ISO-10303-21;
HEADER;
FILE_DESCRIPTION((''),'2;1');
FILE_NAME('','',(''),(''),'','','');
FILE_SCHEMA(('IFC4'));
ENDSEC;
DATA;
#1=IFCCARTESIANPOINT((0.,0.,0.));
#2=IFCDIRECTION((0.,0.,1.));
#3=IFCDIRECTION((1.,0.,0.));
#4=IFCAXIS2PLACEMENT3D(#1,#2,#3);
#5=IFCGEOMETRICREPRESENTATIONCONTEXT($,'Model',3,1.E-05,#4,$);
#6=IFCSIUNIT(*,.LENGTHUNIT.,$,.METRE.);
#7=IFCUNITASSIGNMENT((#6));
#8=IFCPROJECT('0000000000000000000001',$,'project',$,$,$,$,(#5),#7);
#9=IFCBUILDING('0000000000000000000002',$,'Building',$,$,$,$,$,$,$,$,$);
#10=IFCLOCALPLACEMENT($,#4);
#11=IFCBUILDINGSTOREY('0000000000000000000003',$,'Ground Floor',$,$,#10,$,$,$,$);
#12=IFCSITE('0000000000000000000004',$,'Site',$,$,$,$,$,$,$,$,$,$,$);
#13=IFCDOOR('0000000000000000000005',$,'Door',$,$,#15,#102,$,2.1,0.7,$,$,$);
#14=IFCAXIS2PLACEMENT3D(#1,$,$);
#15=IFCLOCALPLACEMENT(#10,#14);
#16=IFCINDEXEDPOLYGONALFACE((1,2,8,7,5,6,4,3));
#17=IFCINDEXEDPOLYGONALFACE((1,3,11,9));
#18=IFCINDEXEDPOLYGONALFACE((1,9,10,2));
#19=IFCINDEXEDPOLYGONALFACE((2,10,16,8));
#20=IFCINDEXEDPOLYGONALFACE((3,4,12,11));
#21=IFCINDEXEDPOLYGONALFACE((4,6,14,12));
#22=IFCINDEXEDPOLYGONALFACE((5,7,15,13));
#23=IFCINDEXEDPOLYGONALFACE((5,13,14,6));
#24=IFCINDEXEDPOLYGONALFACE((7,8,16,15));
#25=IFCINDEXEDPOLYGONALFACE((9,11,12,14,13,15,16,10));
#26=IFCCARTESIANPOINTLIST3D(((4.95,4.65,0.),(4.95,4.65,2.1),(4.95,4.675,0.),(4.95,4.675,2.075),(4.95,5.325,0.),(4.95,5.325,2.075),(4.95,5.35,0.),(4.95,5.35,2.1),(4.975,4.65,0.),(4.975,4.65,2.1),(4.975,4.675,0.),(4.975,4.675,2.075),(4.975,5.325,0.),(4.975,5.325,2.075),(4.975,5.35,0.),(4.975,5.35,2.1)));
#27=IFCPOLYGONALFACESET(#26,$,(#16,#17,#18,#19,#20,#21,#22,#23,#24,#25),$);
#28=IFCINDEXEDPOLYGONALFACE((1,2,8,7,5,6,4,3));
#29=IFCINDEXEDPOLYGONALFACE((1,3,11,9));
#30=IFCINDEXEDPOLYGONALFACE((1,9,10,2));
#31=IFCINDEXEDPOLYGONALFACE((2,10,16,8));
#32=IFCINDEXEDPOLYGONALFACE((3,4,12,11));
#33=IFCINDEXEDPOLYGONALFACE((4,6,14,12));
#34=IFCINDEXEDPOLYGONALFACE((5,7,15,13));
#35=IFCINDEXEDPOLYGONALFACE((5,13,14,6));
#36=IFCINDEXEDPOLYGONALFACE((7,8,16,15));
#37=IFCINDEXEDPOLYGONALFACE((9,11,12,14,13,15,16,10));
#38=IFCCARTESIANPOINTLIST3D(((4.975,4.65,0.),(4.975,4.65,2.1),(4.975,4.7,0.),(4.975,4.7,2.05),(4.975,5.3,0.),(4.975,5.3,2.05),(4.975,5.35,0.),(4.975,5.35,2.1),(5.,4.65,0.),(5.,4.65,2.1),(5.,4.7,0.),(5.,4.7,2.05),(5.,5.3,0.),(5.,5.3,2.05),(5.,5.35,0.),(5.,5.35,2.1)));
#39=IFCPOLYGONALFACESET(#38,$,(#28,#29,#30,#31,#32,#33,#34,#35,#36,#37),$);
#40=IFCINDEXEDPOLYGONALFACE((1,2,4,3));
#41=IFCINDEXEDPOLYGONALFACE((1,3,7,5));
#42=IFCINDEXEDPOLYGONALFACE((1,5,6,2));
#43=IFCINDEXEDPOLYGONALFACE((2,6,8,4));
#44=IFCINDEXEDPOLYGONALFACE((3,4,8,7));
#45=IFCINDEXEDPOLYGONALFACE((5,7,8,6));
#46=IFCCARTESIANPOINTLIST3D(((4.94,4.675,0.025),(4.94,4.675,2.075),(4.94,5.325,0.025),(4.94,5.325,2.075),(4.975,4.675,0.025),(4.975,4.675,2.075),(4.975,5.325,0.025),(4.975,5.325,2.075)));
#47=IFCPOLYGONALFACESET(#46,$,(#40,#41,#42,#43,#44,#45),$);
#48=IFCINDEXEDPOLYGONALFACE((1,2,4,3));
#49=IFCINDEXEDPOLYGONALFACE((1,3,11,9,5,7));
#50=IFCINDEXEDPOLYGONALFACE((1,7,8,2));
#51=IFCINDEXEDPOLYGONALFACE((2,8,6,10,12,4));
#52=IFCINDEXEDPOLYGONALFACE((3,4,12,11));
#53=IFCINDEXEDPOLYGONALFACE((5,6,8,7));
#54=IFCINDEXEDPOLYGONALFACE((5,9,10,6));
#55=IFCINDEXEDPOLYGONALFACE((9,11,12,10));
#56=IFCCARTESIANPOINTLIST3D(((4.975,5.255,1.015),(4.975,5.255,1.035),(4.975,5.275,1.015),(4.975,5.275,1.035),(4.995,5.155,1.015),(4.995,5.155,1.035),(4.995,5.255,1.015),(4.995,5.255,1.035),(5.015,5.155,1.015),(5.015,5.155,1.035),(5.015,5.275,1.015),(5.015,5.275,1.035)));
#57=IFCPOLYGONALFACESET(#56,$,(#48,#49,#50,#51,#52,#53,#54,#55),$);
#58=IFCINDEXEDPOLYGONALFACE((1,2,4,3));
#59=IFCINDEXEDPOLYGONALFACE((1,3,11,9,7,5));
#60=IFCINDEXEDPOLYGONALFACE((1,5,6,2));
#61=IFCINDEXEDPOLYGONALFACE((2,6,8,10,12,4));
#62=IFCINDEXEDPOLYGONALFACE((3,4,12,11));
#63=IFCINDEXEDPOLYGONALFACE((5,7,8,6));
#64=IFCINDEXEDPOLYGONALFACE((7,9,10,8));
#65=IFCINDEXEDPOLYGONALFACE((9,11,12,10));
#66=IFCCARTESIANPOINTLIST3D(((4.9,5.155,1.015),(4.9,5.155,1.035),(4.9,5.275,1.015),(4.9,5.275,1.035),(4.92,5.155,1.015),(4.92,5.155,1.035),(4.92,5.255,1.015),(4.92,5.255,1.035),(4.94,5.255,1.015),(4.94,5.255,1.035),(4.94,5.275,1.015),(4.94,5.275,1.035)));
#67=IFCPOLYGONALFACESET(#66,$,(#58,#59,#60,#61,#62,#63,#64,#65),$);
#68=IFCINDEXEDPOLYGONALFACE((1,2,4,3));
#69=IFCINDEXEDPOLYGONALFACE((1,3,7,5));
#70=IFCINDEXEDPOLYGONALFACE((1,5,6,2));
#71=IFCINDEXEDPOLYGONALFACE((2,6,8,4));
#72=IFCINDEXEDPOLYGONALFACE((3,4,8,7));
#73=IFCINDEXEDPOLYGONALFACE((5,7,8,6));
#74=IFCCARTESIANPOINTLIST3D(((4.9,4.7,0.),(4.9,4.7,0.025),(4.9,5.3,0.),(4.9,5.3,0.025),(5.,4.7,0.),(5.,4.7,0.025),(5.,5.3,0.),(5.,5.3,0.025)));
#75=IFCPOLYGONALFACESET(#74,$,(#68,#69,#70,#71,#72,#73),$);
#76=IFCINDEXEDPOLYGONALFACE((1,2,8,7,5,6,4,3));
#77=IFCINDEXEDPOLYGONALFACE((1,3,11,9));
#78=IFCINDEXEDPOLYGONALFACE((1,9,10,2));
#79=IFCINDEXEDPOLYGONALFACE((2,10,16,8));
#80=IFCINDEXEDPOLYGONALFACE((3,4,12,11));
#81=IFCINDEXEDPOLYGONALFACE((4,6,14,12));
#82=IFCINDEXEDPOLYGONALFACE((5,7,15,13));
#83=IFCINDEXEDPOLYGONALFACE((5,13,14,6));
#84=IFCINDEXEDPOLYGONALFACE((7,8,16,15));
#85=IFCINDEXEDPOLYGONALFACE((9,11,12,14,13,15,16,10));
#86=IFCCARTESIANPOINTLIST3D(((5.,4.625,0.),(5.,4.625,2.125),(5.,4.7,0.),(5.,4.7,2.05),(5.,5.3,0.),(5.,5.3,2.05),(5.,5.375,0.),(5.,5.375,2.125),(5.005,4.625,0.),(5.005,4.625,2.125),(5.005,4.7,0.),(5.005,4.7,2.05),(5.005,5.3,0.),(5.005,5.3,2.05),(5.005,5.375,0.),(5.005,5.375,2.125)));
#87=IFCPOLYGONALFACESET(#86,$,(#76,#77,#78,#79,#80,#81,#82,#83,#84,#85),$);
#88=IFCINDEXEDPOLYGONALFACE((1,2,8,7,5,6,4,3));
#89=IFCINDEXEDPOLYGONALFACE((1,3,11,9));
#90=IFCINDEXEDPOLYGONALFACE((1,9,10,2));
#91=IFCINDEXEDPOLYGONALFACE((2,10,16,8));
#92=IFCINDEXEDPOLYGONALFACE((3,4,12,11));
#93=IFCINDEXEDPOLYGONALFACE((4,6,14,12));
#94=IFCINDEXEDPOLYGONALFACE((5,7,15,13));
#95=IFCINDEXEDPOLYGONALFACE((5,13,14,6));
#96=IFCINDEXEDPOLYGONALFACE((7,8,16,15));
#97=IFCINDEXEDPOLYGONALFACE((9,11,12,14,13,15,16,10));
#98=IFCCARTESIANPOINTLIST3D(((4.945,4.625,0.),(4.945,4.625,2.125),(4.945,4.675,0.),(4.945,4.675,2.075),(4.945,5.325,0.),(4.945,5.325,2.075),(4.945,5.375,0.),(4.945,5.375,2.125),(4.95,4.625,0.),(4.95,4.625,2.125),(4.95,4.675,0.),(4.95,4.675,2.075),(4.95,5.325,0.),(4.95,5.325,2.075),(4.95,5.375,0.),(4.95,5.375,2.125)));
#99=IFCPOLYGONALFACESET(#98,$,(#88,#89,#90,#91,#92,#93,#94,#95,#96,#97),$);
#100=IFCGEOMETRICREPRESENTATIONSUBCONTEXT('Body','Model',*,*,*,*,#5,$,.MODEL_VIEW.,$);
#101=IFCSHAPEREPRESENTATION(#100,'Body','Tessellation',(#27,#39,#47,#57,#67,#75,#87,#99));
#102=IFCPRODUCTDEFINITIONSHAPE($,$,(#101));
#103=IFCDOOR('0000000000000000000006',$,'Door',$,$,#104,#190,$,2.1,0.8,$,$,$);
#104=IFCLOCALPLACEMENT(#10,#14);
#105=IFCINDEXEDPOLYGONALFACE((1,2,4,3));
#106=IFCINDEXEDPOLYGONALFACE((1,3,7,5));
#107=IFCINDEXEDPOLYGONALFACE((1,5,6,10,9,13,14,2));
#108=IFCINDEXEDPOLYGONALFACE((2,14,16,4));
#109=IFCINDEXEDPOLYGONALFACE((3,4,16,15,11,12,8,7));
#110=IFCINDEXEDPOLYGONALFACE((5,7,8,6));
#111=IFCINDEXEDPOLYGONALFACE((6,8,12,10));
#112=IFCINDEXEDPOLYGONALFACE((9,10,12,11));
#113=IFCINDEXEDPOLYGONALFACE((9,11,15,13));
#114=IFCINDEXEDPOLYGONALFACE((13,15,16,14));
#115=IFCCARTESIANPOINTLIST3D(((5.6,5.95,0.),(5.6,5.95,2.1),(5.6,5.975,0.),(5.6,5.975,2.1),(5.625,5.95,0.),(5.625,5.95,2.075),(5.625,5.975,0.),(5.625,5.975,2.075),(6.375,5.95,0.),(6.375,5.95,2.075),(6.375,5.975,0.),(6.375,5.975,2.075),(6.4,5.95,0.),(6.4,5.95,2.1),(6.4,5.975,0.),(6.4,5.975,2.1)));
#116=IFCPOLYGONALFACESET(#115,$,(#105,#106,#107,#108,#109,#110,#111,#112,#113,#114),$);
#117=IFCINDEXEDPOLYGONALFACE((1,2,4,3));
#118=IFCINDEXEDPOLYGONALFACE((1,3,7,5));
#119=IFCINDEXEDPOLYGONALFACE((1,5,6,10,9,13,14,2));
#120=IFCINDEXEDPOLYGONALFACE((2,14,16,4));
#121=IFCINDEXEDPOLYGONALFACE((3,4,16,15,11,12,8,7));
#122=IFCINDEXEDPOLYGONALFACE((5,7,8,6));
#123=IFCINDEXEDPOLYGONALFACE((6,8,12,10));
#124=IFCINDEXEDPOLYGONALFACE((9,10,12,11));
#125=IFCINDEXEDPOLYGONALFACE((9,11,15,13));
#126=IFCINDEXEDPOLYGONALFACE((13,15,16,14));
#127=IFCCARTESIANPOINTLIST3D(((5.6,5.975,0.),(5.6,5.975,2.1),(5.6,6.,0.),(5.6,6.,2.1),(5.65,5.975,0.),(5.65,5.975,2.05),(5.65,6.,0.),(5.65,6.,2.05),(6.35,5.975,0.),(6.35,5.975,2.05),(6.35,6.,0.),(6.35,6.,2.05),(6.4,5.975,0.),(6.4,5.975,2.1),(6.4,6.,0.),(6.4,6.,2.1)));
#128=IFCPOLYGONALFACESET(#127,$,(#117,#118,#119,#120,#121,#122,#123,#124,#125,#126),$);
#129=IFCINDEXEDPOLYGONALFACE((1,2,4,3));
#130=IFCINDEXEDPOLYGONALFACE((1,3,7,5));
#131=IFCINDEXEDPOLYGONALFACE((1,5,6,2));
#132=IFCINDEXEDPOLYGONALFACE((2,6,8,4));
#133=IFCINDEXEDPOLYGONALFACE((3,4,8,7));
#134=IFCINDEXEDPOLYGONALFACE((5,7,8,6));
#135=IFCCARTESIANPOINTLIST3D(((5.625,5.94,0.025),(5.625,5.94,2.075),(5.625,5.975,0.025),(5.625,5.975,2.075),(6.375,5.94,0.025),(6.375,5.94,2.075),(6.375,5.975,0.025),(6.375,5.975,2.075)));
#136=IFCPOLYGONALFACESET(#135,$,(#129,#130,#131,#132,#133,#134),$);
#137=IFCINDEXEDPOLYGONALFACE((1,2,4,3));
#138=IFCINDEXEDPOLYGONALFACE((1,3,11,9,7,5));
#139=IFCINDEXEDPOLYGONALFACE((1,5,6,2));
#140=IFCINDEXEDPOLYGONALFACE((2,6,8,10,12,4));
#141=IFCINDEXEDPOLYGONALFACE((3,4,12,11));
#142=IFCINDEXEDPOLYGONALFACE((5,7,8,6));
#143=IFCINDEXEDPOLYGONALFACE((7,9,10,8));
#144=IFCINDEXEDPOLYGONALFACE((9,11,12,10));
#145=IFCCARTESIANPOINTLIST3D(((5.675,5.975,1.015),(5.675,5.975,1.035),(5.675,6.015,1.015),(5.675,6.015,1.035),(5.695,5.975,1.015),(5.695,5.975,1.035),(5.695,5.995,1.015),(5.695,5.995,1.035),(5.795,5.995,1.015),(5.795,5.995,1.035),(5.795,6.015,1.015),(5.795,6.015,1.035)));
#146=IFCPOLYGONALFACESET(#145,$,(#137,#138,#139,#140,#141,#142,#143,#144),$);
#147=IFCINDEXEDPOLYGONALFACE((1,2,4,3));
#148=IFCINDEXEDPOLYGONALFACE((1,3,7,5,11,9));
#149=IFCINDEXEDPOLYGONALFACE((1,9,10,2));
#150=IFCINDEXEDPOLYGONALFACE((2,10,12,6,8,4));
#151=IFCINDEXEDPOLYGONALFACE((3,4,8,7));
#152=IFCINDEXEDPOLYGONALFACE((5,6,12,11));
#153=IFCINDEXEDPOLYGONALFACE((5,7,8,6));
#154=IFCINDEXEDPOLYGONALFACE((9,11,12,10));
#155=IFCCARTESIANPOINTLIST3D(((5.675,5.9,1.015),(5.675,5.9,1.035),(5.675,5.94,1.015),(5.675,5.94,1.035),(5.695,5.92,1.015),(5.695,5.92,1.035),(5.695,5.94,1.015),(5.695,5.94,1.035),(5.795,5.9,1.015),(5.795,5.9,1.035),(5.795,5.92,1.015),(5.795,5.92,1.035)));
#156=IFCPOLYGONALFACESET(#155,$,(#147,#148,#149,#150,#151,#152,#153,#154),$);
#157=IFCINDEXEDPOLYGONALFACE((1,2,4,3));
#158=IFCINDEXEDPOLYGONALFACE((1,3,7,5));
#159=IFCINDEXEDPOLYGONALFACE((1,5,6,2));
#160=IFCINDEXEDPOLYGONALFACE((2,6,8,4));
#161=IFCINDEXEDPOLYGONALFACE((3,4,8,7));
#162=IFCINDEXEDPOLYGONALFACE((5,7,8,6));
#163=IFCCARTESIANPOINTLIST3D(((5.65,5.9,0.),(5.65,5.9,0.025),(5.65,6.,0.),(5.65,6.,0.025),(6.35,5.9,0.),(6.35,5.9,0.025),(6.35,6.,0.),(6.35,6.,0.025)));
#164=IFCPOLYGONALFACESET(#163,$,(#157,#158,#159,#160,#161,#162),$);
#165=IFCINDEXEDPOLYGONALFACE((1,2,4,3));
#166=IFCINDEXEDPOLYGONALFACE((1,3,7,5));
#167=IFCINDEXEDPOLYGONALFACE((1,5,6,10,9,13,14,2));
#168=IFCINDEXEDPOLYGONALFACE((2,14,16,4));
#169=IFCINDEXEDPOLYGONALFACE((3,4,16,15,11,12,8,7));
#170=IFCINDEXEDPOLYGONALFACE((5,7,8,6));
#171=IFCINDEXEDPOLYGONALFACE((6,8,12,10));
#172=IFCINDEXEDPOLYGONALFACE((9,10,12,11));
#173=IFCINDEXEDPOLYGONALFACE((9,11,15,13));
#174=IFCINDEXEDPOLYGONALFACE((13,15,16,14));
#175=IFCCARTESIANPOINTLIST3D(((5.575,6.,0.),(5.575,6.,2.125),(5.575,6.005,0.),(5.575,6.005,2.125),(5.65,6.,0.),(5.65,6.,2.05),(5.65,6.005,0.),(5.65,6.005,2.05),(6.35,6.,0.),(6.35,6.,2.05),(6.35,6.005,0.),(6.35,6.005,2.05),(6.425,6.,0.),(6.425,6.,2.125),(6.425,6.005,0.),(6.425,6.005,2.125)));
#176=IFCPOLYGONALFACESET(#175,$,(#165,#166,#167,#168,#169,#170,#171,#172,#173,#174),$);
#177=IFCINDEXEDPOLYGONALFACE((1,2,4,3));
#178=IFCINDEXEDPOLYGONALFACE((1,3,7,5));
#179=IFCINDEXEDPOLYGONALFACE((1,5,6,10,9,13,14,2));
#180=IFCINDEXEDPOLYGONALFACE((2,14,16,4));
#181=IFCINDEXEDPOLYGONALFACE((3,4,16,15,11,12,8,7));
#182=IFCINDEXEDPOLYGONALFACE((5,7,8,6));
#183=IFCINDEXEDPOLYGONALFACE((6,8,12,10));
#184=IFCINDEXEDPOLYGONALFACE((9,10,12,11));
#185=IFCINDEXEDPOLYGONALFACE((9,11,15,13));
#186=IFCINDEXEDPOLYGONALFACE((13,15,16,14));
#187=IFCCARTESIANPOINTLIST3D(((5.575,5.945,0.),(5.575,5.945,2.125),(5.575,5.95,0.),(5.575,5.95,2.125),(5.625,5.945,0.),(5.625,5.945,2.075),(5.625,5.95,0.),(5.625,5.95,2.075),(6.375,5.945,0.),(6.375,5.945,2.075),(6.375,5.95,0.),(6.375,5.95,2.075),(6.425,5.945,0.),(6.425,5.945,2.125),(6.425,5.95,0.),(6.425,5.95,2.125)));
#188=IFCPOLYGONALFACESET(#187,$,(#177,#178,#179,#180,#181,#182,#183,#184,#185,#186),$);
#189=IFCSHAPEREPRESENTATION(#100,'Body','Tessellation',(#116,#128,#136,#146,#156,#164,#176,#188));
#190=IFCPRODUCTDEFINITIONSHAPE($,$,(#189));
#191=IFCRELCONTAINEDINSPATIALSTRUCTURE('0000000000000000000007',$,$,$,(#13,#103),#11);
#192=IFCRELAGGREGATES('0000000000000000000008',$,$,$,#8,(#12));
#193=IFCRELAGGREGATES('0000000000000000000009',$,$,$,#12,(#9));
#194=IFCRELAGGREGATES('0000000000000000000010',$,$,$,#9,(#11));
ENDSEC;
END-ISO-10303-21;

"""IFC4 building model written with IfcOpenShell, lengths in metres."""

from ifc_helpers import new_model, si_unit, frame, origin_with_axes, place, context, subcontext, project, spatial, line, indexed_curve, outline, extrude, element, save


model = new_model("IFC4")

# Units and contexts
model_context = context("Model", 3, precision=1e-05, world=origin_with_axes())
body_context = subcontext(model_context, "Body", "Model", "MODEL_VIEW")
ifc_project = project(units=[si_unit("LENGTHUNIT", "METRE")], contexts=[model_context])

# Site, building, storey
site = spatial("IfcSite", under=ifc_project, Name="Site")
building = spatial("IfcBuilding", under=site, Name="Building")
storey_placement = place(None, origin_with_axes())
storey = spatial("IfcBuildingStorey", under=building, at=storey_placement, Name="Ground Floor")

# Doors
door_1_placement = place(storey_placement, frame((5.0, 4.65, 0.0), z_axis=(0.0, 0.0, 1.0), x_axis=(0.0, 1.0, 0.0)))
element("IfcDoor", 1, at=door_1_placement, inside=storey, Name="Door", OverallHeight=2.1, OverallWidth=0.7, context=body_context, shape_type="SweptSolid", body=[
    extrude(outline(indexed_curve([(0.0, 0.0), (0.0, 2.1), (0.7, 2.1), (0.7, 0.0), (0.675, 0.0), (0.675, 2.075), (0.025, 2.075), (0.025, 0.0)], segments=[line(1, 2, 3, 4, 5, 6, 7, 8, 1)])), frame((0.0, 0.025, 0.0), z_axis=(0.0, -1.0, 0.0), x_axis=(1.0, 0.0, 0.0)), (0.0, 0.0, -1.0), 0.025),
    extrude(outline(indexed_curve([(0.0, 0.0), (0.0, 2.1), (0.7, 2.1), (0.7, 0.0), (0.65, 0.0), (0.65, 2.05), (0.05, 2.05), (0.05, 0.0)], segments=[line(1, 2, 3, 4, 5, 6, 7, 8, 1)])), frame((0.0, 0.0, 0.0), z_axis=(0.0, -1.0, 0.0), x_axis=(1.0, 0.0, 0.0)), (0.0, 0.0, -1.0), 0.025),
    extrude(outline(indexed_curve([(0.0, 0.0), (0.65, 0.0), (0.65, 0.035), (0.0, 0.035)], segments=[line(1, 2, 3, 4, 1)])), frame((0.025, 0.025, 0.025), z_axis=(0.0, 0.0, 1.0), x_axis=(1.0, 0.0, 0.0)), (0.0, 0.0, 1.0), 2.05),
    extrude(outline(indexed_curve([(0.0, 0.0), (0.0, -0.04), (-0.12, -0.04), (-0.12, -0.02), (-0.02, -0.02), (-0.02, 0.0)], segments=[line(1, 2, 3, 4, 5, 6, 1)])), frame((0.625, 0.025, 1.015), z_axis=(0.0, 0.0, 1.0), x_axis=(1.0, 0.0, 0.0)), (0.0, 0.0, 1.0), 0.02),
    extrude(outline(indexed_curve([(0.0, 0.0), (0.0, 0.04), (-0.12, 0.04), (-0.12, 0.02), (-0.02, 0.02), (-0.02, 0.0)], segments=[line(1, 2, 3, 4, 5, 6, 1)])), frame((0.625, 0.06, 1.015), z_axis=(0.0, 0.0, 1.0), x_axis=(1.0, 0.0, 0.0)), (0.0, 0.0, 1.0), 0.02),
    extrude(outline(indexed_curve([(0.0, 0.0), (0.6, 0.0), (0.6, 0.1), (0.0, 0.1)], segments=[line(1, 2, 3, 4, 1)])), frame((0.05, 0.0, 0.0), z_axis=(0.0, 0.0, 1.0), x_axis=(1.0, 0.0, 0.0)), (0.0, 0.0, 1.0), 0.025),
    extrude(outline(indexed_curve([(0.0, 0.0), (0.0, 2.125), (0.75, 2.125), (0.75, 0.0), (0.675, 0.0), (0.675, 2.05), (0.075, 2.05), (0.075, 0.0)], segments=[line(1, 2, 3, 4, 5, 6, 7, 8, 1)])), frame((-0.025, -0.005, 0.0), z_axis=(0.0, -1.0, 0.0), x_axis=(1.0, 0.0, 0.0)), (0.0, 0.0, -1.0), 0.005),
    extrude(outline(indexed_curve([(0.0, 0.0), (0.0, 2.125), (0.75, 2.125), (0.75, 0.0), (0.7, 0.0), (0.7, 2.075), (0.05, 2.075), (0.05, 0.0)], segments=[line(1, 2, 3, 4, 5, 6, 7, 8, 1)])), frame((-0.025, 0.05, 0.0), z_axis=(0.0, -1.0, 0.0), x_axis=(1.0, 0.0, 0.0)), (0.0, 0.0, -1.0), 0.005),
])
door_2_placement = place(storey_placement, frame((6.4, 6.0, 0.0), z_axis=(0.0, 0.0, 1.0), x_axis=(-1.0, 0.0, 0.0)))
element("IfcDoor", 2, at=door_2_placement, inside=storey, Name="Door", OverallHeight=2.1, OverallWidth=0.8, context=body_context, shape_type="SweptSolid", body=[
    extrude(outline(indexed_curve([(0.0, 0.0), (0.0, 2.1), (0.8, 2.1), (0.8, 0.0), (0.775, 0.0), (0.775, 2.075), (0.025, 2.075), (0.025, 0.0)], segments=[line(1, 2, 3, 4, 5, 6, 7, 8, 1)])), frame((0.0, 0.025, 0.0), z_axis=(0.0, -1.0, 0.0), x_axis=(1.0, 0.0, 0.0)), (0.0, 0.0, -1.0), 0.025),
    extrude(outline(indexed_curve([(0.0, 0.0), (0.0, 2.1), (0.8, 2.1), (0.8, 0.0), (0.75, 0.0), (0.75, 2.05), (0.05, 2.05), (0.05, 0.0)], segments=[line(1, 2, 3, 4, 5, 6, 7, 8, 1)])), frame((0.0, 0.0, 0.0), z_axis=(0.0, -1.0, 0.0), x_axis=(1.0, 0.0, 0.0)), (0.0, 0.0, -1.0), 0.025),
    extrude(outline(indexed_curve([(0.0, 0.0), (0.75, 0.0), (0.75, 0.035), (0.0, 0.035)], segments=[line(1, 2, 3, 4, 1)])), frame((0.025, 0.025, 0.025), z_axis=(0.0, 0.0, 1.0), x_axis=(1.0, 0.0, 0.0)), (0.0, 0.0, 1.0), 2.05),
    extrude(outline(indexed_curve([(0.0, 0.0), (0.0, -0.04), (-0.12, -0.04), (-0.12, -0.02), (-0.02, -0.02), (-0.02, 0.0)], segments=[line(1, 2, 3, 4, 5, 6, 1)])), frame((0.725, 0.025, 1.015), z_axis=(0.0, 0.0, 1.0), x_axis=(1.0, 0.0, 0.0)), (0.0, 0.0, 1.0), 0.02),
    extrude(outline(indexed_curve([(0.0, 0.0), (0.0, 0.04), (-0.12, 0.04), (-0.12, 0.02), (-0.02, 0.02), (-0.02, 0.0)], segments=[line(1, 2, 3, 4, 5, 6, 1)])), frame((0.725, 0.06, 1.015), z_axis=(0.0, 0.0, 1.0), x_axis=(1.0, 0.0, 0.0)), (0.0, 0.0, 1.0), 0.02),
    extrude(outline(indexed_curve([(0.0, 0.0), (0.7, 0.0), (0.7, 0.1), (0.0, 0.1)], segments=[line(1, 2, 3, 4, 1)])), frame((0.05, 0.0, 0.0), z_axis=(0.0, 0.0, 1.0), x_axis=(1.0, 0.0, 0.0)), (0.0, 0.0, 1.0), 0.025),
    extrude(outline(indexed_curve([(0.0, 0.0), (0.0, 2.125), (0.85, 2.125), (0.85, 0.0), (0.775, 0.0), (0.775, 2.05), (0.075, 2.05), (0.075, 0.0)], segments=[line(1, 2, 3, 4, 5, 6, 7, 8, 1)])), frame((-0.025, -0.005, 0.0), z_axis=(0.0, -1.0, 0.0), x_axis=(1.0, 0.0, 0.0)), (0.0, 0.0, -1.0), 0.005),
    extrude(outline(indexed_curve([(0.0, 0.0), (0.0, 2.125), (0.85, 2.125), (0.85, 0.0), (0.8, 0.0), (0.8, 2.075), (0.05, 2.075), (0.05, 0.0)], segments=[line(1, 2, 3, 4, 5, 6, 7, 8, 1)])), frame((-0.025, 0.05, 0.0), z_axis=(0.0, -1.0, 0.0), x_axis=(1.0, 0.0, 0.0)), (0.0, 0.0, -1.0), 0.005),
])

save(model, "model.ifc")
